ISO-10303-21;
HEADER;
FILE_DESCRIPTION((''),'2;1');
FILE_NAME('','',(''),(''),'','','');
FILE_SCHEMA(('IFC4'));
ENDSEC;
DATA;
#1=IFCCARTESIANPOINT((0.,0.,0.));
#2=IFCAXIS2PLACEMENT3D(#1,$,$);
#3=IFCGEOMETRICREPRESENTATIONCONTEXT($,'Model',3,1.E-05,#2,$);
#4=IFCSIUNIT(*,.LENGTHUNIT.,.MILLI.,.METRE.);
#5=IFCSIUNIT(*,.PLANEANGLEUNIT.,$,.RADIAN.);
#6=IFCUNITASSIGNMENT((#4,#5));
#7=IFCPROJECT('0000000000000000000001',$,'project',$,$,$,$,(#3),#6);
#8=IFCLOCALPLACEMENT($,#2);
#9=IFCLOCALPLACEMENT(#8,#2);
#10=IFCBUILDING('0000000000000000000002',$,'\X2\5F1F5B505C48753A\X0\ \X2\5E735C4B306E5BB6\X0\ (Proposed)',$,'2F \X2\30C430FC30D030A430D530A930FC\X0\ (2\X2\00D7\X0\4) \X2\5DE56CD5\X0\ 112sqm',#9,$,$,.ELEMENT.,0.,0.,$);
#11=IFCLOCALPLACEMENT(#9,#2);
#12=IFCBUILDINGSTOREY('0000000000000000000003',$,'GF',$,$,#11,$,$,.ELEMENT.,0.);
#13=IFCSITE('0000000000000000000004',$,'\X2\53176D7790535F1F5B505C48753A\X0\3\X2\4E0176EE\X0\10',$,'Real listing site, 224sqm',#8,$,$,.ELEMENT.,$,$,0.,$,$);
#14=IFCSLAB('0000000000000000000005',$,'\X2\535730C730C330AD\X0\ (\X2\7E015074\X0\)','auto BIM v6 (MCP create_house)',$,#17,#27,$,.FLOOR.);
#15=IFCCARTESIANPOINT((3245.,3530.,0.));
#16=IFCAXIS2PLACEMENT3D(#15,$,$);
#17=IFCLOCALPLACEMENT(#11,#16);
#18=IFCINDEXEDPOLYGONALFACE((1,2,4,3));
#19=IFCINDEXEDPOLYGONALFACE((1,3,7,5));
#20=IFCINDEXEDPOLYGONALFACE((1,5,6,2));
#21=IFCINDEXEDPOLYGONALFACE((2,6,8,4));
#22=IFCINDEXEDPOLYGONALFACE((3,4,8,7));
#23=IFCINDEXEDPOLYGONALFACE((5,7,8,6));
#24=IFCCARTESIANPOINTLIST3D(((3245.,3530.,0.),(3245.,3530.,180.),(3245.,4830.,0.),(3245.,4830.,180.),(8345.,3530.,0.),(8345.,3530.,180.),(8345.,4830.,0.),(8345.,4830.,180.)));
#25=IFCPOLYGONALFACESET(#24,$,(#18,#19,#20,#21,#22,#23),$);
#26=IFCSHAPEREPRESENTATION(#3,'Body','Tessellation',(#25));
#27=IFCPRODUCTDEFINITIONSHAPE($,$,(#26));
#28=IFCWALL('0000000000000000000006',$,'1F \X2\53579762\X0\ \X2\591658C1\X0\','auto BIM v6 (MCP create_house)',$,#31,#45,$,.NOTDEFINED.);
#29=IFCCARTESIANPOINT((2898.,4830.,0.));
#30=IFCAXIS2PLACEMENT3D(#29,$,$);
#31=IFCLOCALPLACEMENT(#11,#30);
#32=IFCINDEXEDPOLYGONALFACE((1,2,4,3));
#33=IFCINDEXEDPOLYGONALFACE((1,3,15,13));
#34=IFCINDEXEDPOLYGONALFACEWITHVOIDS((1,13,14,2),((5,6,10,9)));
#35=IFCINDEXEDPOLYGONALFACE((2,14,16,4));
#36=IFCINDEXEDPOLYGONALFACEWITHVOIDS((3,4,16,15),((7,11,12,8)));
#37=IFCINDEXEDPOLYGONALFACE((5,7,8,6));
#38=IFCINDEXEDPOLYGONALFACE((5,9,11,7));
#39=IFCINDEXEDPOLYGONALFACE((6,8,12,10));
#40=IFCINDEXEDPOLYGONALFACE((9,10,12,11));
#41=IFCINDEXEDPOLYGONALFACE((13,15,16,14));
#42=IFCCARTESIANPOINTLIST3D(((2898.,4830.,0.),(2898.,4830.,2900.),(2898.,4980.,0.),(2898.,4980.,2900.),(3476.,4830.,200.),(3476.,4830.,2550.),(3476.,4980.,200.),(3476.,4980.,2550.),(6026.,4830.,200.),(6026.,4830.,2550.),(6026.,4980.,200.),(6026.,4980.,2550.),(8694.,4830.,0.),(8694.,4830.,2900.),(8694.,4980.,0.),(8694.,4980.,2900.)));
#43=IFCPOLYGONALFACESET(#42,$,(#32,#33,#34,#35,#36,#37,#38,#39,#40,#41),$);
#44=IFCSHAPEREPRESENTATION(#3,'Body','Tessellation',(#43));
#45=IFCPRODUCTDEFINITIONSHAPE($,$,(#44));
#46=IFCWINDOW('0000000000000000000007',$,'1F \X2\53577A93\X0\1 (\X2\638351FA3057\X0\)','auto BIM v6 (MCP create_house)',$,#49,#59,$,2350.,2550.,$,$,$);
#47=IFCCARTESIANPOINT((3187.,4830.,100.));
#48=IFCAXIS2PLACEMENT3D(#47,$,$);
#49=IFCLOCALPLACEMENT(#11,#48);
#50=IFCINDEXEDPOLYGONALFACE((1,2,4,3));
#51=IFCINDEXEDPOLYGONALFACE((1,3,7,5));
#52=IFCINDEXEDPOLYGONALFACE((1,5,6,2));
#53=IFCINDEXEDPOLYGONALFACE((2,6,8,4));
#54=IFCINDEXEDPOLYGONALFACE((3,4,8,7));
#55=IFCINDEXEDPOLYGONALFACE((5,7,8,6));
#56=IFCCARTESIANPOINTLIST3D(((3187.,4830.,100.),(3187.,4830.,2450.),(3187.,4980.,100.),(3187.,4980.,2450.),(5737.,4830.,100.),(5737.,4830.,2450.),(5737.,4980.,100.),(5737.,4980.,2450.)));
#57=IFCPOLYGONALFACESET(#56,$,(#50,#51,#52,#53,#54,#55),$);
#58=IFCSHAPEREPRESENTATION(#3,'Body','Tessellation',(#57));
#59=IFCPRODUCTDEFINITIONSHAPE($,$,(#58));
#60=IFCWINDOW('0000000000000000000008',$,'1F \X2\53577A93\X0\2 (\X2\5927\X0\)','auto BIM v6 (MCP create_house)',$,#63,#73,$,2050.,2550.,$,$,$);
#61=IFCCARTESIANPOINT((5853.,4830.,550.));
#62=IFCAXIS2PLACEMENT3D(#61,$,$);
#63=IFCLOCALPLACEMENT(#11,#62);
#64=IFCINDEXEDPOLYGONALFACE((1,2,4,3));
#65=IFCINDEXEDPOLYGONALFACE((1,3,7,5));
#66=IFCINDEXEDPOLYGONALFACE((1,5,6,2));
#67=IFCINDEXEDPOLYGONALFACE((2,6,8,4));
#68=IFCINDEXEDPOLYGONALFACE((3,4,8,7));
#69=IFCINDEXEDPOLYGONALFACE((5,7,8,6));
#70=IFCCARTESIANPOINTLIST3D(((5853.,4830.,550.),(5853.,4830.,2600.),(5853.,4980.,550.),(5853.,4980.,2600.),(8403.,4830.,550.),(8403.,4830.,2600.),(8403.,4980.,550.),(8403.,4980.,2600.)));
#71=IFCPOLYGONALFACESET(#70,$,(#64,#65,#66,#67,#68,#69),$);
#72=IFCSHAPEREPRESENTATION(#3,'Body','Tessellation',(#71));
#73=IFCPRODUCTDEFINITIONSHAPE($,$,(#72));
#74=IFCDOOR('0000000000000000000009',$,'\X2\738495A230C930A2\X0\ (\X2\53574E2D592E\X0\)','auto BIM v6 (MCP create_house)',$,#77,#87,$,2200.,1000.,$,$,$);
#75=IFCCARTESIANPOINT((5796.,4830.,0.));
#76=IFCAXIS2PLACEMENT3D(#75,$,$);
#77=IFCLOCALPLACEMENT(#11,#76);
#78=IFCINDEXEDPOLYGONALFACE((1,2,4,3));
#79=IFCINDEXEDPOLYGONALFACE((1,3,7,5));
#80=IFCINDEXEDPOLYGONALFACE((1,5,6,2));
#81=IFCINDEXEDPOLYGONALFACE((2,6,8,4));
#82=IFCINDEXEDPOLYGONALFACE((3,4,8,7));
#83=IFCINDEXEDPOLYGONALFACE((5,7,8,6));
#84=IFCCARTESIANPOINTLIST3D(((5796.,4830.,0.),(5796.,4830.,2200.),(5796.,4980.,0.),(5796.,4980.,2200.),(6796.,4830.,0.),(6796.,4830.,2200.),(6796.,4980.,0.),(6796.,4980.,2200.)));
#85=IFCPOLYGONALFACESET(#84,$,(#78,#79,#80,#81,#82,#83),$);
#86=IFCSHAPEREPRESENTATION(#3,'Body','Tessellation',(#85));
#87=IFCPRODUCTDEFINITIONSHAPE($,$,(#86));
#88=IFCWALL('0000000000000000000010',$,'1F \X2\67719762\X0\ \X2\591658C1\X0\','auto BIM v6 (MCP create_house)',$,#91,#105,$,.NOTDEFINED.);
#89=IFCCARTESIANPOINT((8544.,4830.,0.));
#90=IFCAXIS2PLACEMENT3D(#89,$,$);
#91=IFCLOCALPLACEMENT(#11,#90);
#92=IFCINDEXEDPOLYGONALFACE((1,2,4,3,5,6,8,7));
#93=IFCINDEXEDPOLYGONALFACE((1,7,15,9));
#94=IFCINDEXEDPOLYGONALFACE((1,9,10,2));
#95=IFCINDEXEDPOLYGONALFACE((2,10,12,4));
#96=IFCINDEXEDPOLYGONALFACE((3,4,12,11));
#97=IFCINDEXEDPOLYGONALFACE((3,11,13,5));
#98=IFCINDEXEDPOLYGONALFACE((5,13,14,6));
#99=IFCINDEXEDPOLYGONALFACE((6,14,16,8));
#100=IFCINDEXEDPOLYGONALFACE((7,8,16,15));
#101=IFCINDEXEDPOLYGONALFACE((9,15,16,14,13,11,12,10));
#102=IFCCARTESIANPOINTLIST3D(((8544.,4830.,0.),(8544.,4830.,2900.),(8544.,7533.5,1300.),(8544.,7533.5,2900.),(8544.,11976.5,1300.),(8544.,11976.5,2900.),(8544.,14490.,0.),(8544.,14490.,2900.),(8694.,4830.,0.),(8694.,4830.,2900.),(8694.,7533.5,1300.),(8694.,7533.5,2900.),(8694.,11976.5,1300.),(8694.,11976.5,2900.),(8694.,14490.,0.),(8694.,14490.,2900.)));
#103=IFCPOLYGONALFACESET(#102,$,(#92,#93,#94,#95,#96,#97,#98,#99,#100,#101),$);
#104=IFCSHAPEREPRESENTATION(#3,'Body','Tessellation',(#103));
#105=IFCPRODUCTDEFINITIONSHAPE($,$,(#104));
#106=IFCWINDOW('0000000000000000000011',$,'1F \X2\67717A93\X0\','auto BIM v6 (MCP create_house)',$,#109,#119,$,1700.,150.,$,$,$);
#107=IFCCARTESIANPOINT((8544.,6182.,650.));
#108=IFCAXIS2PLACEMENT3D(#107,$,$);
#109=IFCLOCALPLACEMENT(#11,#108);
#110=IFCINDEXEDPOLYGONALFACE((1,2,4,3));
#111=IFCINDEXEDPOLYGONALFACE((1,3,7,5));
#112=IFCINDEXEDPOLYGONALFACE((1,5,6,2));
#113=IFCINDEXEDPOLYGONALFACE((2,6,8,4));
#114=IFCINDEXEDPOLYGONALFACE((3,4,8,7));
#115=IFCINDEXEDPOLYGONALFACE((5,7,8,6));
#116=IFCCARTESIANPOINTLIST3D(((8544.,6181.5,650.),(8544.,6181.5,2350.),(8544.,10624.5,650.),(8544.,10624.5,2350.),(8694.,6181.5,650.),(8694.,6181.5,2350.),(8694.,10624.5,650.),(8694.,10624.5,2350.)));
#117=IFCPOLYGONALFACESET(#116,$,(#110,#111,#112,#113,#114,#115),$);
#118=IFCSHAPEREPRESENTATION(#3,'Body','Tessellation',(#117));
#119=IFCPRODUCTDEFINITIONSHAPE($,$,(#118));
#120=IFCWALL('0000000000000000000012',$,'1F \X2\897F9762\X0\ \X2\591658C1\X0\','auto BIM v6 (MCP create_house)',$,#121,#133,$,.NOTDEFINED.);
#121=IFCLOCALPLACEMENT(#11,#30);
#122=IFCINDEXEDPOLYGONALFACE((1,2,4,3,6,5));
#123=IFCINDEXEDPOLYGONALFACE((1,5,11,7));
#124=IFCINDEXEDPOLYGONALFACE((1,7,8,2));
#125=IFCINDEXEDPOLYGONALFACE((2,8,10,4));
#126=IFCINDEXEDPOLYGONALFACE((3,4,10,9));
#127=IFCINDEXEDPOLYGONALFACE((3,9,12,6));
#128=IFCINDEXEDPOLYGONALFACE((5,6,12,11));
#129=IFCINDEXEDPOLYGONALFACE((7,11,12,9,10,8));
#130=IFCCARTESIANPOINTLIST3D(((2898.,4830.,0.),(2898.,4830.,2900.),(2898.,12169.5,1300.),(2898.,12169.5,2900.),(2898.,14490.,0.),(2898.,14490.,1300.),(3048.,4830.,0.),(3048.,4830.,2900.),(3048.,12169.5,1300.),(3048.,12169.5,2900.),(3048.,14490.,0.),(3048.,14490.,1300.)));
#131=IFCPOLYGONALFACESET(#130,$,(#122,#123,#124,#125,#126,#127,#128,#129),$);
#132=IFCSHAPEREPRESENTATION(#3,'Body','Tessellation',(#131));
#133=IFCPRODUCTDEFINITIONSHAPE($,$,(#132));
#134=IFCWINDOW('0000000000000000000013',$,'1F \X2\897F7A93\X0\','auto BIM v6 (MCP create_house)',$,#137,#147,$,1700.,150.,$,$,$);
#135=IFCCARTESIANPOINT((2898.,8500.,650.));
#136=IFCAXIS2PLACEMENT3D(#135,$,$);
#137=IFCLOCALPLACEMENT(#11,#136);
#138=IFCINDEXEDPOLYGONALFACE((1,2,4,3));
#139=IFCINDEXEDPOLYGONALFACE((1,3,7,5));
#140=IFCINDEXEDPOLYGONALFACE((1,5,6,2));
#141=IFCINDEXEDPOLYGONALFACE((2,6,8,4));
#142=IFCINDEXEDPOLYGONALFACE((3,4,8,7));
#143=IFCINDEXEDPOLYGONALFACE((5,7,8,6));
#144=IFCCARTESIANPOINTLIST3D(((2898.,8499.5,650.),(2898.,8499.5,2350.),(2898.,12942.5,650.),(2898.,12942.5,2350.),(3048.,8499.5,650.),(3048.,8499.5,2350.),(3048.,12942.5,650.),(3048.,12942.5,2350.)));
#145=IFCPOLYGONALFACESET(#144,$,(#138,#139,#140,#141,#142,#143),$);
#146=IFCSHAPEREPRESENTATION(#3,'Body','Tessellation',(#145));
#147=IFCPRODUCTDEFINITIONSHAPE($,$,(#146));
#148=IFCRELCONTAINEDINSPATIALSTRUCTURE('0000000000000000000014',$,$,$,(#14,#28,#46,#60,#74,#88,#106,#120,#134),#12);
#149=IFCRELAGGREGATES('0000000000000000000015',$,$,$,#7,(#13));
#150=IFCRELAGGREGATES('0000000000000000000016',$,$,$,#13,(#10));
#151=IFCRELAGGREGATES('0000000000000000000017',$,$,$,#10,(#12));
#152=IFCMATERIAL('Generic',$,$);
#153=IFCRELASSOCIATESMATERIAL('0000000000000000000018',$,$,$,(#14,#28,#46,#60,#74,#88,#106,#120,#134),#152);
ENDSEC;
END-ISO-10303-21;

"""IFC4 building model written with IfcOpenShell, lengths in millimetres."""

from ifc_helpers import new_model, si_unit, frame, frame_2d, origin, place, context, project, spatial, rectangle, extrude, material, element, fill, save


model = new_model("IFC4")

# Units and contexts
model_context = context("Model", 3, precision=1e-05, world=origin())
ifc_project = project(units=[si_unit("LENGTHUNIT", "METRE", prefix="MILLI"), si_unit("PLANEANGLEUNIT", "RADIAN")], contexts=[model_context])

# Site, building, storey
site_placement = place(None, origin())
site = spatial("IfcSite", under=ifc_project, at=site_placement, Name="北海道弟子屈町3丁目10", ObjectType="Real listing site, 224sqm", CompositionType="ELEMENT", RefElevation=0.0)
building_placement = place(site_placement, origin())
building = spatial("IfcBuilding", under=site, at=building_placement, Name="弟子屈町 平屋の家 (Proposed)", ObjectType="2F ツーバイフォー (2×4) 工法 112sqm", CompositionType="ELEMENT", ElevationOfRefHeight=0.0, ElevationOfTerrain=0.0)
storey_placement = place(building_placement, origin())
storey = spatial("IfcBuildingStorey", under=building, at=storey_placement, Name="GF", CompositionType="ELEMENT", Elevation=0.0)

# Slab
ifc_material = material(Name="Generic")
slab_1_placement = place(storey_placement, frame((3245.0, 3530.0, 0.0)))
element("IfcSlab", 1, at=slab_1_placement, inside=storey, material=ifc_material, Name="南デッキ (縁側)", Description="auto BIM v6 (MCP create_house)", PredefinedType="FLOOR", context=model_context, shape_type="SweptSolid", body=[
    extrude(rectangle(XDim=5100.0, YDim=1300.0, at=frame_2d((2550.0, 650.0))), frame((3245.0, 3530.0, 0.0)), (0.0, 0.0, 1.0), 180.0),
])

# Wall, openings, windows, door
wall_1_placement = place(storey_placement, frame((2898.0, 4830.0, 0.0)))
wall_1 = element("IfcWall", 2, at=wall_1_placement, inside=storey, material=ifc_material, Name="1F 南面 外壁", Description="auto BIM v6 (MCP create_house)", PredefinedType="NOTDEFINED", context=model_context, shape_type="SweptSolid", body=[
    extrude(rectangle(XDim=5796.0, YDim=150.0, at=frame_2d((2898.0, 75.0))), frame((2898.0, 4830.0, 0.0)), (0.0, 0.0, 1.0), 2900.0),
])
opening_1_placement = place(storey_placement, frame((3187.0, 4830.0, 100.0)))
opening_1 = element("IfcOpeningElement", 3, at=opening_1_placement, cuts=wall_1, PredefinedType="NOTDEFINED", context=model_context, shape_type="SweptSolid", body=[
    extrude(rectangle(XDim=2550.0, YDim=150.0, at=frame_2d((1275.0, 75.0))), frame((3187.0, 4830.0, 100.0)), (0.0, 0.0, 1.0), 2350.0),
])
opening_2_placement = place(storey_placement, frame((5853.0, 4830.0, 550.0)))
opening_2 = element("IfcOpeningElement", 4, at=opening_2_placement, cuts=wall_1, PredefinedType="NOTDEFINED", context=model_context, shape_type="SweptSolid", body=[
    extrude(rectangle(XDim=2550.0, YDim=150.0, at=frame_2d((1275.0, 75.0))), frame((5853.0, 4830.0, 550.0)), (0.0, 0.0, 1.0), 2050.0),
])
opening_3_placement = place(storey_placement, frame((5796.0, 4830.0, 0.0)))
opening_3 = element("IfcOpeningElement", 5, at=opening_3_placement, cuts=wall_1, PredefinedType="NOTDEFINED", context=model_context, shape_type="SweptSolid", body=[
    extrude(rectangle(XDim=1000.0, YDim=150.0, at=frame_2d((500.0, 75.0))), frame((5796.0, 4830.0, 0.0)), (0.0, 0.0, 1.0), 2200.0),
])
window_1_placement = place(storey_placement, frame((3187.0, 4830.0, 100.0)))
window_1 = element("IfcWindow", 6, at=window_1_placement, inside=storey, material=ifc_material, Name="1F 南窓1 (掃出し)", Description="auto BIM v6 (MCP create_house)", OverallHeight=2350.0, OverallWidth=2550.0, context=model_context, shape_type="SweptSolid", body=[
    extrude(rectangle(XDim=2550.0, YDim=150.0, at=frame_2d((1275.0, 75.0))), frame((3187.0, 4830.0, 100.0)), (0.0, 0.0, 1.0), 2350.0),
])
fill(opening_1, window_1)
window_2_placement = place(storey_placement, frame((5853.0, 4830.0, 550.0)))
window_2 = element("IfcWindow", 7, at=window_2_placement, inside=storey, material=ifc_material, Name="1F 南窓2 (大)", Description="auto BIM v6 (MCP create_house)", OverallHeight=2050.0, OverallWidth=2550.0, context=model_context, shape_type="SweptSolid", body=[
    extrude(rectangle(XDim=2550.0, YDim=150.0, at=frame_2d((1275.0, 75.0))), frame((5853.0, 4830.0, 550.0)), (0.0, 0.0, 1.0), 2050.0),
])
fill(opening_2, window_2)
door_placement = place(storey_placement, frame((5796.0, 4830.0, 0.0)))
door = element("IfcDoor", 8, at=door_placement, inside=storey, material=ifc_material, Name="玄関ドア (南中央)", Description="auto BIM v6 (MCP create_house)", OverallHeight=2200.0, OverallWidth=1000.0, context=model_context, shape_type="SweptSolid", body=[
    extrude(rectangle(XDim=1000.0, YDim=150.0, at=frame_2d((500.0, 75.0))), frame((5796.0, 4830.0, 0.0)), (0.0, 0.0, 1.0), 2200.0),
])
fill(opening_3, door)

# Walls, openings, windows
wall_2_placement = place(storey_placement, frame((8544.0, 4830.0, 0.0)))
wall_2 = element("IfcWall", 9, at=wall_2_placement, inside=storey, material=ifc_material, Name="1F 東面 外壁", Description="auto BIM v6 (MCP create_house)", PredefinedType="NOTDEFINED", context=model_context, shape_type="SweptSolid", body=[
    extrude(rectangle(XDim=150.0, YDim=9660.0, at=frame_2d((75.0, 4830.0))), frame((8544.0, 4830.0, 0.0)), (0.0, 0.0, 1.0), 2900.0),
])
opening_4_placement = place(storey_placement, frame((8544.0, 6182.0, 650.0)))
opening_4 = element("IfcOpeningElement", 10, at=opening_4_placement, cuts=wall_2, PredefinedType="NOTDEFINED", context=model_context, shape_type="SweptSolid", body=[
    extrude(rectangle(XDim=150.0, YDim=4443.0, at=frame_2d((75.0, 2221.0))), frame((8544.0, 6182.0, 650.0)), (0.0, 0.0, 1.0), 1700.0),
])
window_3_placement = place(storey_placement, frame((8544.0, 6182.0, 650.0)))
window_3 = element("IfcWindow", 11, at=window_3_placement, inside=storey, material=ifc_material, Name="1F 東窓", Description="auto BIM v6 (MCP create_house)", OverallHeight=1700.0, OverallWidth=150.0, context=model_context, shape_type="SweptSolid", body=[
    extrude(rectangle(XDim=150.0, YDim=4443.0, at=frame_2d((75.0, 2221.0))), frame((8544.0, 6182.0, 650.0)), (0.0, 0.0, 1.0), 1700.0),
])
fill(opening_4, window_3)
wall_3_placement = place(storey_placement, frame((2898.0, 4830.0, 0.0)))
wall_3 = element("IfcWall", 12, at=wall_3_placement, inside=storey, material=ifc_material, Name="1F 西面 外壁", Description="auto BIM v6 (MCP create_house)", PredefinedType="NOTDEFINED", context=model_context, shape_type="SweptSolid", body=[
    extrude(rectangle(XDim=150.0, YDim=9660.0, at=frame_2d((75.0, 4830.0))), frame((2898.0, 4830.0, 0.0)), (0.0, 0.0, 1.0), 2900.0),
])
opening_5_placement = place(storey_placement, frame((2898.0, 8500.0, 650.0)))
opening_5 = element("IfcOpeningElement", 13, at=opening_5_placement, cuts=wall_3, PredefinedType="NOTDEFINED", context=model_context, shape_type="SweptSolid", body=[
    extrude(rectangle(XDim=150.0, YDim=4443.0, at=frame_2d((75.0, 2221.0))), frame((2898.0, 8500.0, 650.0)), (0.0, 0.0, 1.0), 1700.0),
])
window_4_placement = place(storey_placement, frame((2898.0, 8500.0, 650.0)))
window_4 = element("IfcWindow", 14, at=window_4_placement, inside=storey, material=ifc_material, Name="1F 西窓", Description="auto BIM v6 (MCP create_house)", OverallHeight=1700.0, OverallWidth=150.0, context=model_context, shape_type="SweptSolid", body=[
    extrude(rectangle(XDim=150.0, YDim=4443.0, at=frame_2d((75.0, 2221.0))), frame((2898.0, 8500.0, 650.0)), (0.0, 0.0, 1.0), 1700.0),
])
fill(opening_5, window_4)

save(model, "model.ifc")
